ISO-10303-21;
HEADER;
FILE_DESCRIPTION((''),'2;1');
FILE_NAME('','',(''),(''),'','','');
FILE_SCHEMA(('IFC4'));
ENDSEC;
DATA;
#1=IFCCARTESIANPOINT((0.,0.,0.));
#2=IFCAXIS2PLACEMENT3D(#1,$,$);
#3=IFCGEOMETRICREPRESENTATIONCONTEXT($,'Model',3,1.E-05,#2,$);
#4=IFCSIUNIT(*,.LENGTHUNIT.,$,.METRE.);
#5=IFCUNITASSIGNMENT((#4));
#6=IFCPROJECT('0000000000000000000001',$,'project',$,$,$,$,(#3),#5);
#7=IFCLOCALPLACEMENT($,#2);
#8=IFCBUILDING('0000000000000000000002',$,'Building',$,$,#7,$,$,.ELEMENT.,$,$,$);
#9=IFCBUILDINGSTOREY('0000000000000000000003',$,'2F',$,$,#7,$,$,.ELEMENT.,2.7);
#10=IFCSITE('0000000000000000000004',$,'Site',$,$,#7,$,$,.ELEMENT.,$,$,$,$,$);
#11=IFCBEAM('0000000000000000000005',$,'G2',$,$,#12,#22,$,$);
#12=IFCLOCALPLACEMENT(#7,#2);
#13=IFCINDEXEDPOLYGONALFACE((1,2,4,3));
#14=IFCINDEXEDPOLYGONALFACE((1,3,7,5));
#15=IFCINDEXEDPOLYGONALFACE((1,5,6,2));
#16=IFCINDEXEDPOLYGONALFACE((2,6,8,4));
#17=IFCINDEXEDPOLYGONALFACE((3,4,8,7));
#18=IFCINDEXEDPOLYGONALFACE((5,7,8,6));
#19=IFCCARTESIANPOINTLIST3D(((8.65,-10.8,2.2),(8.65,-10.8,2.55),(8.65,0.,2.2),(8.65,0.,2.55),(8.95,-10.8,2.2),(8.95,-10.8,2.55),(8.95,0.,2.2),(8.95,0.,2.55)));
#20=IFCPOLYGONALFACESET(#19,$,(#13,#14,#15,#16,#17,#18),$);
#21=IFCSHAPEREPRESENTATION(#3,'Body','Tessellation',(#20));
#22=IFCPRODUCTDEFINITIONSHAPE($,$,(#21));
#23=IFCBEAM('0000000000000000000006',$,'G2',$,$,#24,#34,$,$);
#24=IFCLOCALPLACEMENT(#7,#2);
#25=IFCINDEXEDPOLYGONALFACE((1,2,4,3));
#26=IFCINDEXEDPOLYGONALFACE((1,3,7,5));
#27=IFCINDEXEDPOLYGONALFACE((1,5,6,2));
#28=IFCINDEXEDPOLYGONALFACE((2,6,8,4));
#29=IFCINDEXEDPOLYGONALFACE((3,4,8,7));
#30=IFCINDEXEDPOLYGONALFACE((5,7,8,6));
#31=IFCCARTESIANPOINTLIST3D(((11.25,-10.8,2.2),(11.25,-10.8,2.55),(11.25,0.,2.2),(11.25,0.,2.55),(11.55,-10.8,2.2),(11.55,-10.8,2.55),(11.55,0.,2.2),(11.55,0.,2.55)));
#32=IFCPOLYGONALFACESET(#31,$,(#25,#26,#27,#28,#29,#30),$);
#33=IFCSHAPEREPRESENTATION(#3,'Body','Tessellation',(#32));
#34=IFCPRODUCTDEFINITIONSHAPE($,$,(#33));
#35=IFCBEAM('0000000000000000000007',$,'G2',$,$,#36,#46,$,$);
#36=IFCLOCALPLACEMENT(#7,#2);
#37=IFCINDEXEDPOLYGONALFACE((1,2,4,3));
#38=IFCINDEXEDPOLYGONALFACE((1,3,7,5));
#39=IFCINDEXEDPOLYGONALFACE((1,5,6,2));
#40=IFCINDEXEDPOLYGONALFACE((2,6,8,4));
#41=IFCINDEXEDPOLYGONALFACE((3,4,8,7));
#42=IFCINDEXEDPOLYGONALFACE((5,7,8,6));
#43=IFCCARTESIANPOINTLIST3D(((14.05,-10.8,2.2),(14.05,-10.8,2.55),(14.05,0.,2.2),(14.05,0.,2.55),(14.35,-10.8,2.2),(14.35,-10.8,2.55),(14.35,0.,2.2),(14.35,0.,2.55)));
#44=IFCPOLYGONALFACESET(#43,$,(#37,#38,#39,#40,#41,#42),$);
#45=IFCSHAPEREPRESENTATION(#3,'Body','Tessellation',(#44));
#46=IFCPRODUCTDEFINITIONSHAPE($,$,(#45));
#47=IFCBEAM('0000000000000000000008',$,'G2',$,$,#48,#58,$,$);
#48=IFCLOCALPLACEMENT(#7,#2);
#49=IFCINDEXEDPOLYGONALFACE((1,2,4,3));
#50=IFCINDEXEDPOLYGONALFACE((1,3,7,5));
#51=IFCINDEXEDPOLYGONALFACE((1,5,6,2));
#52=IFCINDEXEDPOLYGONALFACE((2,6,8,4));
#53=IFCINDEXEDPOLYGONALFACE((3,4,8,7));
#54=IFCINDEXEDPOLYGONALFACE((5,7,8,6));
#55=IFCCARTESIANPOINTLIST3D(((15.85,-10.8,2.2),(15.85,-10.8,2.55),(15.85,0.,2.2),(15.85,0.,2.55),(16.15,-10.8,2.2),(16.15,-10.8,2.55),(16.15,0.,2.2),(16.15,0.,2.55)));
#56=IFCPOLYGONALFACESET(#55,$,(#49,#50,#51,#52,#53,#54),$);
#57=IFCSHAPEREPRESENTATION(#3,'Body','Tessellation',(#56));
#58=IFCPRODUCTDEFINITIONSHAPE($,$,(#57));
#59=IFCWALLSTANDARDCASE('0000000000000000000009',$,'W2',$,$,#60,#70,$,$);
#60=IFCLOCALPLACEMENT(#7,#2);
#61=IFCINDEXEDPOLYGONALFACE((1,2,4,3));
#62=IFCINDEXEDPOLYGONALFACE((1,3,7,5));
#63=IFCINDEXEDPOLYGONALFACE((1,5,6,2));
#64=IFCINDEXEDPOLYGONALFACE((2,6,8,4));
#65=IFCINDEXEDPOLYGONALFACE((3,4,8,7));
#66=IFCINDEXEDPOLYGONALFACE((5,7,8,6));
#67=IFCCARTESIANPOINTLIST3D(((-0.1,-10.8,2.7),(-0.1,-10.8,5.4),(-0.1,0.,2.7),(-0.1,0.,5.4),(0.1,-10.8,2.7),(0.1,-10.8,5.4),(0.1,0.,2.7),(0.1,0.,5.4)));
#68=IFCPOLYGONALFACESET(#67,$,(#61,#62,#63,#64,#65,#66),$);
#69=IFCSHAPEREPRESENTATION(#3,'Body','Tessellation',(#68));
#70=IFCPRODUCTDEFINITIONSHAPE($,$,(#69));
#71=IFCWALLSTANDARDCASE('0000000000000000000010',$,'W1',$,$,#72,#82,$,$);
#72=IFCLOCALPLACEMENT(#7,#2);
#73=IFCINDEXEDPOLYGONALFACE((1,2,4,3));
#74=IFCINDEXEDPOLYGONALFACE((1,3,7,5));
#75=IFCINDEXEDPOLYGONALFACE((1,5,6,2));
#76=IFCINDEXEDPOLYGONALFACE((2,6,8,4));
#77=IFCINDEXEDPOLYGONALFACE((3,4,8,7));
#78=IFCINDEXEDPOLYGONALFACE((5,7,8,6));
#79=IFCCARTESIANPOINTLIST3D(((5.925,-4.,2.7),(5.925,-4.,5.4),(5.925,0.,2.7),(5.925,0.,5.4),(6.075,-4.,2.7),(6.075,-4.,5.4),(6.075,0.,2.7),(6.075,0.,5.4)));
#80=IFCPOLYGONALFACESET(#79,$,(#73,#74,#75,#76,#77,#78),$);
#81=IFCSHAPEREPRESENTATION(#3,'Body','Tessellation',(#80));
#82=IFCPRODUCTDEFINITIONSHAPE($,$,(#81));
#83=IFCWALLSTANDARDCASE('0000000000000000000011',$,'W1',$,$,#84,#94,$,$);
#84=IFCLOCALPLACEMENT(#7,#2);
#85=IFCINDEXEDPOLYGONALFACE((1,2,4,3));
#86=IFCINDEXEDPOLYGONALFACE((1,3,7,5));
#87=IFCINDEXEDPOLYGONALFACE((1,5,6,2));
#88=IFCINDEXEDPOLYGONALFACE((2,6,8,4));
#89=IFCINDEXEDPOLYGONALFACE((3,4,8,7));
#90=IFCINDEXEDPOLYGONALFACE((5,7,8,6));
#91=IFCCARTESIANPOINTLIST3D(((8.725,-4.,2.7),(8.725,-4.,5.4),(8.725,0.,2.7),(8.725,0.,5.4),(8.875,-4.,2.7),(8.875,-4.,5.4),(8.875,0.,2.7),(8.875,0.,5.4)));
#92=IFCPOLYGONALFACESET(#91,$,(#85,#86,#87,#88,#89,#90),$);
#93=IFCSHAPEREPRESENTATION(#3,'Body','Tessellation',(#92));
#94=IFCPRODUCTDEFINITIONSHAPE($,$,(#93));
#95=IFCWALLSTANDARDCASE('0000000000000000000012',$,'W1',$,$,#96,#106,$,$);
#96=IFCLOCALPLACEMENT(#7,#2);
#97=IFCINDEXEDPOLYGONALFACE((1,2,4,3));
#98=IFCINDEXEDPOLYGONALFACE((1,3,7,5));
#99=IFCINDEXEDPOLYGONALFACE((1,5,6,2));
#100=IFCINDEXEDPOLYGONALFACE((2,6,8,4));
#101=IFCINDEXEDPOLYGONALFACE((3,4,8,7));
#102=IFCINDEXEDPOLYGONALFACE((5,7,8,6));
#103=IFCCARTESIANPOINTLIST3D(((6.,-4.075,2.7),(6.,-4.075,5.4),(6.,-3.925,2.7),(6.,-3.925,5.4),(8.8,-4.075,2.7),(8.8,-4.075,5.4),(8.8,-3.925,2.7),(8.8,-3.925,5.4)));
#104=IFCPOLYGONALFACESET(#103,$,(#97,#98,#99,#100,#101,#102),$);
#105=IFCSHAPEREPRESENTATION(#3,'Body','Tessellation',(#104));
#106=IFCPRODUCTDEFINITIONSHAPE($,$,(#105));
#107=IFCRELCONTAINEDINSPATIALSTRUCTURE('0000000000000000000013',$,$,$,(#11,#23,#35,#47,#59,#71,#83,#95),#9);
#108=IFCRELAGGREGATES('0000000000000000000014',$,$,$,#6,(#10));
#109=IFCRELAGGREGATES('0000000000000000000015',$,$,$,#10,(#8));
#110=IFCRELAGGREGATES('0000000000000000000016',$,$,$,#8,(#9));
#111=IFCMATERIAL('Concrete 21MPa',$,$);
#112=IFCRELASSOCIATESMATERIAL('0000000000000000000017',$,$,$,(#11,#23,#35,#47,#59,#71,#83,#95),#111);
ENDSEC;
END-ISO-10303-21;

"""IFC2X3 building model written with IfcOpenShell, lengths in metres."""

from ifc_helpers import new_model, si_unit, frame, origin, origin_2d, place, context, project, spatial, rectangle, extrude, material, element, save


model = new_model("IFC2X3")

# Units and contexts
model_context = context("Model", 3, precision=1e-05, world=origin())
ifc_project = project(units=[si_unit("LENGTHUNIT", "METRE")], contexts=[model_context])

# Site, building, storey
placement = place(None, origin())
site = spatial("IfcSite", under=ifc_project, at=placement, Name="Site", CompositionType="ELEMENT")
building = spatial("IfcBuilding", under=site, at=placement, Name="Building", CompositionType="ELEMENT")
storey = spatial("IfcBuildingStorey", under=building, at=placement, Name="2F", CompositionType="ELEMENT", Elevation=2.7)

# Shared definitions
ifc_material = material(Name="Concrete 21MPa")

# Beams
for number, where, name in (
    (1, (8.8, -5.4, 2.2), "G2"),
    (2, (11.4, -5.4, 2.2), "G2"),
    (3, (14.2, -5.4, 2.2), "G2"),
    (4, (16.0, -5.4, 2.2), "G2"),
):
    element("IfcBeam", number, at=place(None, frame(where)), inside=storey, material=ifc_material, Name=name, context=model_context, shape_type="SweptSolid", body=[
        extrude(rectangle(XDim=0.3, YDim=10.8, at=origin_2d()), origin(), (0.0, 0.0, 1.0), 0.35),
    ])

# Walls
wall_1_placement = place(None, frame((0.0, -5.4, 2.7)))
element("IfcWallStandardCase", 5, at=wall_1_placement, inside=storey, material=ifc_material, Name="W2", context=model_context, shape_type="SweptSolid", body=[
    extrude(rectangle(XDim=0.2, YDim=10.8, at=origin_2d()), origin(), (0.0, 0.0, 1.0), 2.7),
])
for number, where, name in (
    (6, (6.0, -2.0, 2.7), "W1"),
    (7, (8.8, -2.0, 2.7), "W1"),
):
    element("IfcWallStandardCase", number, at=place(None, frame(where)), inside=storey, material=ifc_material, Name=name, context=model_context, shape_type="SweptSolid", body=[
        extrude(rectangle(XDim=0.15, YDim=4.0, at=origin_2d()), origin(), (0.0, 0.0, 1.0), 2.7),
    ])
wall_2_placement = place(None, frame((7.4, -4.0, 2.7)))
element("IfcWallStandardCase", 8, at=wall_2_placement, inside=storey, material=ifc_material, Name="W1", context=model_context, shape_type="SweptSolid", body=[
    extrude(rectangle(XDim=2.8, YDim=0.15, at=origin_2d()), origin(), (0.0, 0.0, 1.0), 2.7),
])

save(model, "model.ifc")
